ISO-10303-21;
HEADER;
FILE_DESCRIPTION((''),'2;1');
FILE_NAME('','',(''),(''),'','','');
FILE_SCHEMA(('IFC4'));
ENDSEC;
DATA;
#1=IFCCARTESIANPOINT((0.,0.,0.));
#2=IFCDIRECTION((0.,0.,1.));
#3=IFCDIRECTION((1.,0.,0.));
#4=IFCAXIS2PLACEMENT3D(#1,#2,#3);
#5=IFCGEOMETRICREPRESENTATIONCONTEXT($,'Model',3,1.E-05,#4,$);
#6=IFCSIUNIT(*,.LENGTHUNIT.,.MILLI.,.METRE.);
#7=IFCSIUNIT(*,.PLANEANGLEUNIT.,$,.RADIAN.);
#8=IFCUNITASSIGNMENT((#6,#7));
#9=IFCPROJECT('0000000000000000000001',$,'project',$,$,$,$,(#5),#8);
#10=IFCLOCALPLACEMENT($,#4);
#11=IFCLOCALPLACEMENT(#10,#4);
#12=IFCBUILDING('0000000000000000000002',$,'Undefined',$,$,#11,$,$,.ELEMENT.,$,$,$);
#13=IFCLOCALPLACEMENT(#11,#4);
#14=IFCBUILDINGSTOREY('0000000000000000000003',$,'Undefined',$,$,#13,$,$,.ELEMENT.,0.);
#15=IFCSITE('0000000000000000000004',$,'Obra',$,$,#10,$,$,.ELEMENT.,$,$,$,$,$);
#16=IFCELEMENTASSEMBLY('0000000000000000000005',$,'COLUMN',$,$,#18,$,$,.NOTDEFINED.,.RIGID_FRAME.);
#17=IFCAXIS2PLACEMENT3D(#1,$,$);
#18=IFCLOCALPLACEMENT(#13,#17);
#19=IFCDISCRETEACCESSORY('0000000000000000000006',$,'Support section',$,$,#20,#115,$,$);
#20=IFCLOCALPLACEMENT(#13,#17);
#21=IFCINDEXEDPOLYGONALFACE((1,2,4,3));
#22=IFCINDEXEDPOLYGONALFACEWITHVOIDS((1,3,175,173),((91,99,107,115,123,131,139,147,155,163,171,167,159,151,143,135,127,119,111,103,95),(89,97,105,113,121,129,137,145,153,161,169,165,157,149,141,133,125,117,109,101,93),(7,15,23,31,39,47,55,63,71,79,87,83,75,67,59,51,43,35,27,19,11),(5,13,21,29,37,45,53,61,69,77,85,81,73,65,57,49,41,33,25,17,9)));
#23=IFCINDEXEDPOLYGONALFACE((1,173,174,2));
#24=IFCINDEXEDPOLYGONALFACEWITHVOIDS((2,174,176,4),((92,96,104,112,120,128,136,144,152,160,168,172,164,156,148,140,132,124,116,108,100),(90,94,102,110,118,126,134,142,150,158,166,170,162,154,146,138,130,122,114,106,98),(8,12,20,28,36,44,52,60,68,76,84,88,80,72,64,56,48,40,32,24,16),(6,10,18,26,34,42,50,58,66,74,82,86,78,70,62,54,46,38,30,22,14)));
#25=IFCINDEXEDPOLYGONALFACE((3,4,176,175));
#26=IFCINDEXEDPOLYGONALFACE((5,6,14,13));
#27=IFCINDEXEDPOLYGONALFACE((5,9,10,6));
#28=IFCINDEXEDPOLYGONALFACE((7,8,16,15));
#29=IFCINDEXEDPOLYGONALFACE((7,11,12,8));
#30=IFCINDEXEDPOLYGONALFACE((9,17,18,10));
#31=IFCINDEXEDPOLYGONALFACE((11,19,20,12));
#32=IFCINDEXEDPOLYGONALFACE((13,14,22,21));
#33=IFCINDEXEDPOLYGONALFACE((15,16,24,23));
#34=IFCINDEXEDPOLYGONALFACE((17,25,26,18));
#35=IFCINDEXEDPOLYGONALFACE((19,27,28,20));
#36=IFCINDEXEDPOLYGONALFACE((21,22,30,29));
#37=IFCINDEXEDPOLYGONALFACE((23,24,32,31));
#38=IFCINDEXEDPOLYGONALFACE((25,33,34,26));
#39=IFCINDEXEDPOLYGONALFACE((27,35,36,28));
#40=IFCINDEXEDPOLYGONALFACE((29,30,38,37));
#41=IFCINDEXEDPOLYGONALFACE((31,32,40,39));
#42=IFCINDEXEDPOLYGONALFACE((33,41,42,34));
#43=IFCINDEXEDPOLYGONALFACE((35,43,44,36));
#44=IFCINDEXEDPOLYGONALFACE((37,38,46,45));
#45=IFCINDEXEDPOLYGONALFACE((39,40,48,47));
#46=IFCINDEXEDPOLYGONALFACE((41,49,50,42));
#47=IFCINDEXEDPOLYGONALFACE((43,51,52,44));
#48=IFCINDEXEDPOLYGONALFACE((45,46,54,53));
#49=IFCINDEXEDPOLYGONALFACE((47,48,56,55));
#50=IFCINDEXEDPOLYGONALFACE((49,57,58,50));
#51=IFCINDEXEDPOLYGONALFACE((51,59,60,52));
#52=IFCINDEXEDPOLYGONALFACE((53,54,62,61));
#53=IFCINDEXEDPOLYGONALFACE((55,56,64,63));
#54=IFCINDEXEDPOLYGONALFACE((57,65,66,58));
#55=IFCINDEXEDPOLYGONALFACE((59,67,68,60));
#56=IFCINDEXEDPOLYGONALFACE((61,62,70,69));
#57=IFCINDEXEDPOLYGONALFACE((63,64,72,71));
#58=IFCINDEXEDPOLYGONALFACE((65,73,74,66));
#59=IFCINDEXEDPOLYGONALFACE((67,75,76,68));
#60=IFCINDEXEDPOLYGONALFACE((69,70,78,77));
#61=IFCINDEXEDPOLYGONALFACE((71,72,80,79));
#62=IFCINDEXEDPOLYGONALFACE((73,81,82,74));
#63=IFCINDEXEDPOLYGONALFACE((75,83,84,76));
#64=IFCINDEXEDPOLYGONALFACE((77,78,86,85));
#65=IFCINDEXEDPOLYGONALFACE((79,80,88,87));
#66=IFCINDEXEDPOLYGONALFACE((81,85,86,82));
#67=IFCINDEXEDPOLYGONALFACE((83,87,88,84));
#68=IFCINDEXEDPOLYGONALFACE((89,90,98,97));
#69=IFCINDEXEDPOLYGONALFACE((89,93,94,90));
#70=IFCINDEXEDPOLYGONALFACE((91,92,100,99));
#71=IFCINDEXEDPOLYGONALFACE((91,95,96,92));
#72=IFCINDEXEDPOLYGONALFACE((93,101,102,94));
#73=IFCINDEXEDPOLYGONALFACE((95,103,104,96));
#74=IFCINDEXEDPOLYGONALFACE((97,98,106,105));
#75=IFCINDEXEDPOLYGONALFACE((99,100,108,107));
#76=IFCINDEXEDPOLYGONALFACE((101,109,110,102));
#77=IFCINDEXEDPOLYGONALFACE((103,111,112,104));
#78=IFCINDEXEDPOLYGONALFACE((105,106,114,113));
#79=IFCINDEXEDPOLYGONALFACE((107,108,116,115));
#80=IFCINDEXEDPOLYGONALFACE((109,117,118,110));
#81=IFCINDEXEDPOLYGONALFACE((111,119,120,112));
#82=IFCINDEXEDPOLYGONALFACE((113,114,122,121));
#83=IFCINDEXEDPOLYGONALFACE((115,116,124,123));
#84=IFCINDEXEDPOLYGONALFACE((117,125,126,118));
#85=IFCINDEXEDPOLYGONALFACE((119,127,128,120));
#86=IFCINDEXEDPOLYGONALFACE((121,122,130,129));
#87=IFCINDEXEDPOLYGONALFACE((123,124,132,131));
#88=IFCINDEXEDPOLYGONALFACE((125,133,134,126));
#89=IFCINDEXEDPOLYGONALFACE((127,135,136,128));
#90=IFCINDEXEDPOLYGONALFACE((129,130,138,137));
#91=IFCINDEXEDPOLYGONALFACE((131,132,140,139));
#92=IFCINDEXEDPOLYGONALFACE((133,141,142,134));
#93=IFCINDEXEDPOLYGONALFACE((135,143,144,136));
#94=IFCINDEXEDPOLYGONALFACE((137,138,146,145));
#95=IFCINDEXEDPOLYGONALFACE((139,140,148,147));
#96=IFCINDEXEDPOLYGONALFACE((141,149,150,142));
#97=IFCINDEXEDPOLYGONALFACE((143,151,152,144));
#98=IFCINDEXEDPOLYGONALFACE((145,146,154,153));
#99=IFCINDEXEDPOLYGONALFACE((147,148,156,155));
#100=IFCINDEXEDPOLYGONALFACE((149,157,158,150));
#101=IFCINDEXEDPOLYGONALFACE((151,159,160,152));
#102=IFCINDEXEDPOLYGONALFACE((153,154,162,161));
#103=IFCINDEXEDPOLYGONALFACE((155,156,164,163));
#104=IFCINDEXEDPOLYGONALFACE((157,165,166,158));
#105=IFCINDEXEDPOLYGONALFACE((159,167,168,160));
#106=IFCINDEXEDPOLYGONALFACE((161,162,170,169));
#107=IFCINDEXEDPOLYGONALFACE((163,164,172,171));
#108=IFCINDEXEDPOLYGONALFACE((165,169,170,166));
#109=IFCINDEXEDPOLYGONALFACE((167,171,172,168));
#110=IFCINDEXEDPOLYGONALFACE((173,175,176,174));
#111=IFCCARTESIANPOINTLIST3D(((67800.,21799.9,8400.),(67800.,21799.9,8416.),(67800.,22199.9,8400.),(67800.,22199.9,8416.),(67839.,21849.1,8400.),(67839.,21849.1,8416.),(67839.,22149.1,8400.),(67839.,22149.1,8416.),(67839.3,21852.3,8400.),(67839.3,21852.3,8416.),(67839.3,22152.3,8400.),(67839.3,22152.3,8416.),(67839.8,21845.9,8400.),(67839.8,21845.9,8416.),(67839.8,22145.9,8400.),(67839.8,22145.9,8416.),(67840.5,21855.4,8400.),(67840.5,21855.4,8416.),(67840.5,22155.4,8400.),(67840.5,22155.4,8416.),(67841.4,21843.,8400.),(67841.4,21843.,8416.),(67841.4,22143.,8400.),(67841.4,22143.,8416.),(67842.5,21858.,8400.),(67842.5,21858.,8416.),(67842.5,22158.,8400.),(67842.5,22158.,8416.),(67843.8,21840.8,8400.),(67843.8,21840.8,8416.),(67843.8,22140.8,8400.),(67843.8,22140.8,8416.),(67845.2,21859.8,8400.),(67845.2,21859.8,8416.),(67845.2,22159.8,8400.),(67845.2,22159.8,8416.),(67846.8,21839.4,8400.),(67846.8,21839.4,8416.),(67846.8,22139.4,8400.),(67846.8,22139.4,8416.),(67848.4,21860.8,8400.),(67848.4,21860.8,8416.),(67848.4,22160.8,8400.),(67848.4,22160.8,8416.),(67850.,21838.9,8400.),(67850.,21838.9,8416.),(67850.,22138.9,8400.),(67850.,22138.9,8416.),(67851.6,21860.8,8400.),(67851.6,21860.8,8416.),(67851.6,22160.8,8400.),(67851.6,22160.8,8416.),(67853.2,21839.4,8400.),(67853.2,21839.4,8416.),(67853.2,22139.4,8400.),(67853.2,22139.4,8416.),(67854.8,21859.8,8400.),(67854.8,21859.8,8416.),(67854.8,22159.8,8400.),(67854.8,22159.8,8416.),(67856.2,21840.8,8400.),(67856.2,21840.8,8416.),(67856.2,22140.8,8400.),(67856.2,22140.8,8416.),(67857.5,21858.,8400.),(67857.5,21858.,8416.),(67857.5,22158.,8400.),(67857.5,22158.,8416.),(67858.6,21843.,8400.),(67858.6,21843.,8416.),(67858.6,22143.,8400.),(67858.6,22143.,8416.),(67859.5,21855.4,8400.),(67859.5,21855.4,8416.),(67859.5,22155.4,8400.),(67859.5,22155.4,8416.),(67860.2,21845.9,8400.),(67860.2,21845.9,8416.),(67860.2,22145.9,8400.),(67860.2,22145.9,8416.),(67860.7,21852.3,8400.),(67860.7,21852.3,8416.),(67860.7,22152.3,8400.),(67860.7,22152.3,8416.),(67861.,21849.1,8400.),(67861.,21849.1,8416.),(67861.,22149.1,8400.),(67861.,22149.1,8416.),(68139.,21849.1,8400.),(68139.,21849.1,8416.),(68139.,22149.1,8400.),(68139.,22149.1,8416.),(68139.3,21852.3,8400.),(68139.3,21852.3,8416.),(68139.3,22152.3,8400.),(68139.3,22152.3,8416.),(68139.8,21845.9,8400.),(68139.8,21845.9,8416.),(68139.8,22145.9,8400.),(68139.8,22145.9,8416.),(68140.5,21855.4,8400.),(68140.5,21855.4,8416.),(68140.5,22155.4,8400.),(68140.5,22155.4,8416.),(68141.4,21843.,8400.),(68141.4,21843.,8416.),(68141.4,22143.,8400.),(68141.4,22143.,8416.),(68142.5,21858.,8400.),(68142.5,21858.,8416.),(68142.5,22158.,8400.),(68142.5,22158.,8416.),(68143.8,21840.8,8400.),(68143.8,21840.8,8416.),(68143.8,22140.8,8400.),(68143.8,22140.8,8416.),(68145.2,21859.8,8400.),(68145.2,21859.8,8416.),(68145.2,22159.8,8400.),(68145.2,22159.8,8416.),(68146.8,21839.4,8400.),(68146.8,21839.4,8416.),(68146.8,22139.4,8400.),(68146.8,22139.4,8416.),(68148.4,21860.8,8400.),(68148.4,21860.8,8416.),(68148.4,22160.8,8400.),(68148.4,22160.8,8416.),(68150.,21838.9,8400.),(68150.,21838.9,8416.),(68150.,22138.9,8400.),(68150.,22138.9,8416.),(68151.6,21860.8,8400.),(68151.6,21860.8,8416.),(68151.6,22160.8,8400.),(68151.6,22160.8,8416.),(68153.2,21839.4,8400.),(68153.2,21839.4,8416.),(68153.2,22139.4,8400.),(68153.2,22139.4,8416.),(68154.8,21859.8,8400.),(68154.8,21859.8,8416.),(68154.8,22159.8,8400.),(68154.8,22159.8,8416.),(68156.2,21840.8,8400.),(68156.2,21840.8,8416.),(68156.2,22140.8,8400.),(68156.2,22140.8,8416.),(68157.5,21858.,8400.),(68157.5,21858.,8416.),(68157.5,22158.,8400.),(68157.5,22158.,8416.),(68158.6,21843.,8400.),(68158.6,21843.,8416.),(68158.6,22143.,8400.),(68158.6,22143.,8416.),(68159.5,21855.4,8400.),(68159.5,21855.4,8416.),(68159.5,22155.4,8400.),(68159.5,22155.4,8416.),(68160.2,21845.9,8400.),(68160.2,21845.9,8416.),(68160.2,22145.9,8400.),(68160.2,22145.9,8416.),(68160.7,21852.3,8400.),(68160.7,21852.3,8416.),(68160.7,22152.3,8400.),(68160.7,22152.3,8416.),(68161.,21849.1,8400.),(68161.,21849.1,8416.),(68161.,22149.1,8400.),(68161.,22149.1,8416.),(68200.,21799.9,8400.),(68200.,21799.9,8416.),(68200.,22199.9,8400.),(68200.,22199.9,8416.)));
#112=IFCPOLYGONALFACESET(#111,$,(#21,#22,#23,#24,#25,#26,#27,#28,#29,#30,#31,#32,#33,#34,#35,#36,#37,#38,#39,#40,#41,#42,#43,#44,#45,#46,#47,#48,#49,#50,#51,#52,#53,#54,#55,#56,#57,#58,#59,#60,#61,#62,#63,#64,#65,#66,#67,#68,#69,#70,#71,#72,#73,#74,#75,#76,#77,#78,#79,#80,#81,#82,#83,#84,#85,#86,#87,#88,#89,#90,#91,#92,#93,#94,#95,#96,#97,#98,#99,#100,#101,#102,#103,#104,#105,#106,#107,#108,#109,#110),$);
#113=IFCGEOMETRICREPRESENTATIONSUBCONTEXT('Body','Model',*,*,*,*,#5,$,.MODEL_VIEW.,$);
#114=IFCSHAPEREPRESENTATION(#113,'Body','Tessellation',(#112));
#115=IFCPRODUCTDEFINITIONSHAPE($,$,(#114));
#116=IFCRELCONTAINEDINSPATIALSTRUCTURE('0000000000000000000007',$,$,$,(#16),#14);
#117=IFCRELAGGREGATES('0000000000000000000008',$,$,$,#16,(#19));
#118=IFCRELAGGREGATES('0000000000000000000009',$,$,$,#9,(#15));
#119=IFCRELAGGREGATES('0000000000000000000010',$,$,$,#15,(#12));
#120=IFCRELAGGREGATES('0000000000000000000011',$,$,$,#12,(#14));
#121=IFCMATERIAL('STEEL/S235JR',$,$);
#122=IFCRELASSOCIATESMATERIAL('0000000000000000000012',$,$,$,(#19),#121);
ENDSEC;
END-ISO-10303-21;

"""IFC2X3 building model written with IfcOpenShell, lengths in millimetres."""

from ifc_helpers import new_model, si_unit, frame, origin_with_axes, origin_2d_with_axis, place, context, subcontext, project, spatial, rectangle, circle, extrude, source, transform, mapped, material, element, aggregate, save


model = new_model("IFC2X3")

# Units and contexts
model_context = context("Model", 3, precision=1e-05, world=origin_with_axes())
body_context = subcontext(model_context, "Body", "Model", "MODEL_VIEW")
ifc_project = project(units=[si_unit("LENGTHUNIT", "METRE", prefix="MILLI"), si_unit("PLANEANGLEUNIT", "RADIAN")], contexts=[model_context])

# Site, building, storey
site_placement = place(None, origin_with_axes())
site = spatial("IfcSite", under=ifc_project, at=site_placement, Name="Obra", CompositionType="ELEMENT")
building_placement = place(site_placement, origin_with_axes())
building = spatial("IfcBuilding", under=site, at=building_placement, Name="Undefined", CompositionType="ELEMENT")
storey_placement = place(building_placement, origin_with_axes())
storey = spatial("IfcBuildingStorey", under=building, at=storey_placement, Name="Undefined", CompositionType="ELEMENT", Elevation=0.0)

# Element assembly
assembly_1_placement = place(storey_placement, origin_with_axes())
assembly_1 = element("IfcElementAssembly", 1, at=assembly_1_placement, inside=storey, Name="COLUMN", AssemblyPlace="NOTDEFINED", PredefinedType="RIGID_FRAME")
ifc_material_1 = material(Name="STEEL/S235JR")

# Discrete accessory, opening
discrete_accessory_1_placement = place(assembly_1_placement, frame((68000.0, 21799.9, 8408.0), z_axis=(-1.0, 0.0, 0.0), x_axis=(0.0, 1.0, 0.0)))
discrete_accessory_1 = element("IfcDiscreteAccessory", 2, at=discrete_accessory_1_placement, material=ifc_material_1, Name="Support section", context=body_context, shape_type="SweptSolid", body=[
    extrude(rectangle(XDim=16.0, YDim=400.0, at=origin_2d_with_axis()), frame((400.0, 0.0, 0.0), z_axis=(-1.0, 0.0, 0.0), x_axis=(0.0, -1.0, 0.0)), (0.0, 0.0, 1.0), 400.0),
])
shared_shape_1 = source(origin_with_axes(), body_context, "Body", "SweptSolid", [
    extrude(circle(Radius=11.0, at=origin_2d_with_axis()), frame((0.0, -0.1, 0.0), z_axis=(0.0, 1.0, 0.0), x_axis=(1.0, 0.0, 0.0)), (0.0, 0.0, 1.0), 16.2),
])
opening_1_placement = place(assembly_1_placement, frame((68000.0, 22152.4, 8416.0), z_axis=(1.0, 0.0, 0.0), x_axis=(0.0, -1.0, 0.0)))
element("IfcOpeningElement", 3, at=opening_1_placement, cuts=discrete_accessory_1, ObjectType="Opening", context=body_context, shape_type="MappedRepresentation", body=[
    mapped(shared_shape_1, transform((2.5, 0.0, 150.0))),
    mapped(shared_shape_1, transform((2.5, 0.0, -150.0))),
    mapped(shared_shape_1, transform((302.5, 0.0, 150.0))),
    mapped(shared_shape_1, transform((302.5, 0.0, -150.0))),
])
aggregate(assembly_1, [discrete_accessory_1])

save(model, "model.ifc")
